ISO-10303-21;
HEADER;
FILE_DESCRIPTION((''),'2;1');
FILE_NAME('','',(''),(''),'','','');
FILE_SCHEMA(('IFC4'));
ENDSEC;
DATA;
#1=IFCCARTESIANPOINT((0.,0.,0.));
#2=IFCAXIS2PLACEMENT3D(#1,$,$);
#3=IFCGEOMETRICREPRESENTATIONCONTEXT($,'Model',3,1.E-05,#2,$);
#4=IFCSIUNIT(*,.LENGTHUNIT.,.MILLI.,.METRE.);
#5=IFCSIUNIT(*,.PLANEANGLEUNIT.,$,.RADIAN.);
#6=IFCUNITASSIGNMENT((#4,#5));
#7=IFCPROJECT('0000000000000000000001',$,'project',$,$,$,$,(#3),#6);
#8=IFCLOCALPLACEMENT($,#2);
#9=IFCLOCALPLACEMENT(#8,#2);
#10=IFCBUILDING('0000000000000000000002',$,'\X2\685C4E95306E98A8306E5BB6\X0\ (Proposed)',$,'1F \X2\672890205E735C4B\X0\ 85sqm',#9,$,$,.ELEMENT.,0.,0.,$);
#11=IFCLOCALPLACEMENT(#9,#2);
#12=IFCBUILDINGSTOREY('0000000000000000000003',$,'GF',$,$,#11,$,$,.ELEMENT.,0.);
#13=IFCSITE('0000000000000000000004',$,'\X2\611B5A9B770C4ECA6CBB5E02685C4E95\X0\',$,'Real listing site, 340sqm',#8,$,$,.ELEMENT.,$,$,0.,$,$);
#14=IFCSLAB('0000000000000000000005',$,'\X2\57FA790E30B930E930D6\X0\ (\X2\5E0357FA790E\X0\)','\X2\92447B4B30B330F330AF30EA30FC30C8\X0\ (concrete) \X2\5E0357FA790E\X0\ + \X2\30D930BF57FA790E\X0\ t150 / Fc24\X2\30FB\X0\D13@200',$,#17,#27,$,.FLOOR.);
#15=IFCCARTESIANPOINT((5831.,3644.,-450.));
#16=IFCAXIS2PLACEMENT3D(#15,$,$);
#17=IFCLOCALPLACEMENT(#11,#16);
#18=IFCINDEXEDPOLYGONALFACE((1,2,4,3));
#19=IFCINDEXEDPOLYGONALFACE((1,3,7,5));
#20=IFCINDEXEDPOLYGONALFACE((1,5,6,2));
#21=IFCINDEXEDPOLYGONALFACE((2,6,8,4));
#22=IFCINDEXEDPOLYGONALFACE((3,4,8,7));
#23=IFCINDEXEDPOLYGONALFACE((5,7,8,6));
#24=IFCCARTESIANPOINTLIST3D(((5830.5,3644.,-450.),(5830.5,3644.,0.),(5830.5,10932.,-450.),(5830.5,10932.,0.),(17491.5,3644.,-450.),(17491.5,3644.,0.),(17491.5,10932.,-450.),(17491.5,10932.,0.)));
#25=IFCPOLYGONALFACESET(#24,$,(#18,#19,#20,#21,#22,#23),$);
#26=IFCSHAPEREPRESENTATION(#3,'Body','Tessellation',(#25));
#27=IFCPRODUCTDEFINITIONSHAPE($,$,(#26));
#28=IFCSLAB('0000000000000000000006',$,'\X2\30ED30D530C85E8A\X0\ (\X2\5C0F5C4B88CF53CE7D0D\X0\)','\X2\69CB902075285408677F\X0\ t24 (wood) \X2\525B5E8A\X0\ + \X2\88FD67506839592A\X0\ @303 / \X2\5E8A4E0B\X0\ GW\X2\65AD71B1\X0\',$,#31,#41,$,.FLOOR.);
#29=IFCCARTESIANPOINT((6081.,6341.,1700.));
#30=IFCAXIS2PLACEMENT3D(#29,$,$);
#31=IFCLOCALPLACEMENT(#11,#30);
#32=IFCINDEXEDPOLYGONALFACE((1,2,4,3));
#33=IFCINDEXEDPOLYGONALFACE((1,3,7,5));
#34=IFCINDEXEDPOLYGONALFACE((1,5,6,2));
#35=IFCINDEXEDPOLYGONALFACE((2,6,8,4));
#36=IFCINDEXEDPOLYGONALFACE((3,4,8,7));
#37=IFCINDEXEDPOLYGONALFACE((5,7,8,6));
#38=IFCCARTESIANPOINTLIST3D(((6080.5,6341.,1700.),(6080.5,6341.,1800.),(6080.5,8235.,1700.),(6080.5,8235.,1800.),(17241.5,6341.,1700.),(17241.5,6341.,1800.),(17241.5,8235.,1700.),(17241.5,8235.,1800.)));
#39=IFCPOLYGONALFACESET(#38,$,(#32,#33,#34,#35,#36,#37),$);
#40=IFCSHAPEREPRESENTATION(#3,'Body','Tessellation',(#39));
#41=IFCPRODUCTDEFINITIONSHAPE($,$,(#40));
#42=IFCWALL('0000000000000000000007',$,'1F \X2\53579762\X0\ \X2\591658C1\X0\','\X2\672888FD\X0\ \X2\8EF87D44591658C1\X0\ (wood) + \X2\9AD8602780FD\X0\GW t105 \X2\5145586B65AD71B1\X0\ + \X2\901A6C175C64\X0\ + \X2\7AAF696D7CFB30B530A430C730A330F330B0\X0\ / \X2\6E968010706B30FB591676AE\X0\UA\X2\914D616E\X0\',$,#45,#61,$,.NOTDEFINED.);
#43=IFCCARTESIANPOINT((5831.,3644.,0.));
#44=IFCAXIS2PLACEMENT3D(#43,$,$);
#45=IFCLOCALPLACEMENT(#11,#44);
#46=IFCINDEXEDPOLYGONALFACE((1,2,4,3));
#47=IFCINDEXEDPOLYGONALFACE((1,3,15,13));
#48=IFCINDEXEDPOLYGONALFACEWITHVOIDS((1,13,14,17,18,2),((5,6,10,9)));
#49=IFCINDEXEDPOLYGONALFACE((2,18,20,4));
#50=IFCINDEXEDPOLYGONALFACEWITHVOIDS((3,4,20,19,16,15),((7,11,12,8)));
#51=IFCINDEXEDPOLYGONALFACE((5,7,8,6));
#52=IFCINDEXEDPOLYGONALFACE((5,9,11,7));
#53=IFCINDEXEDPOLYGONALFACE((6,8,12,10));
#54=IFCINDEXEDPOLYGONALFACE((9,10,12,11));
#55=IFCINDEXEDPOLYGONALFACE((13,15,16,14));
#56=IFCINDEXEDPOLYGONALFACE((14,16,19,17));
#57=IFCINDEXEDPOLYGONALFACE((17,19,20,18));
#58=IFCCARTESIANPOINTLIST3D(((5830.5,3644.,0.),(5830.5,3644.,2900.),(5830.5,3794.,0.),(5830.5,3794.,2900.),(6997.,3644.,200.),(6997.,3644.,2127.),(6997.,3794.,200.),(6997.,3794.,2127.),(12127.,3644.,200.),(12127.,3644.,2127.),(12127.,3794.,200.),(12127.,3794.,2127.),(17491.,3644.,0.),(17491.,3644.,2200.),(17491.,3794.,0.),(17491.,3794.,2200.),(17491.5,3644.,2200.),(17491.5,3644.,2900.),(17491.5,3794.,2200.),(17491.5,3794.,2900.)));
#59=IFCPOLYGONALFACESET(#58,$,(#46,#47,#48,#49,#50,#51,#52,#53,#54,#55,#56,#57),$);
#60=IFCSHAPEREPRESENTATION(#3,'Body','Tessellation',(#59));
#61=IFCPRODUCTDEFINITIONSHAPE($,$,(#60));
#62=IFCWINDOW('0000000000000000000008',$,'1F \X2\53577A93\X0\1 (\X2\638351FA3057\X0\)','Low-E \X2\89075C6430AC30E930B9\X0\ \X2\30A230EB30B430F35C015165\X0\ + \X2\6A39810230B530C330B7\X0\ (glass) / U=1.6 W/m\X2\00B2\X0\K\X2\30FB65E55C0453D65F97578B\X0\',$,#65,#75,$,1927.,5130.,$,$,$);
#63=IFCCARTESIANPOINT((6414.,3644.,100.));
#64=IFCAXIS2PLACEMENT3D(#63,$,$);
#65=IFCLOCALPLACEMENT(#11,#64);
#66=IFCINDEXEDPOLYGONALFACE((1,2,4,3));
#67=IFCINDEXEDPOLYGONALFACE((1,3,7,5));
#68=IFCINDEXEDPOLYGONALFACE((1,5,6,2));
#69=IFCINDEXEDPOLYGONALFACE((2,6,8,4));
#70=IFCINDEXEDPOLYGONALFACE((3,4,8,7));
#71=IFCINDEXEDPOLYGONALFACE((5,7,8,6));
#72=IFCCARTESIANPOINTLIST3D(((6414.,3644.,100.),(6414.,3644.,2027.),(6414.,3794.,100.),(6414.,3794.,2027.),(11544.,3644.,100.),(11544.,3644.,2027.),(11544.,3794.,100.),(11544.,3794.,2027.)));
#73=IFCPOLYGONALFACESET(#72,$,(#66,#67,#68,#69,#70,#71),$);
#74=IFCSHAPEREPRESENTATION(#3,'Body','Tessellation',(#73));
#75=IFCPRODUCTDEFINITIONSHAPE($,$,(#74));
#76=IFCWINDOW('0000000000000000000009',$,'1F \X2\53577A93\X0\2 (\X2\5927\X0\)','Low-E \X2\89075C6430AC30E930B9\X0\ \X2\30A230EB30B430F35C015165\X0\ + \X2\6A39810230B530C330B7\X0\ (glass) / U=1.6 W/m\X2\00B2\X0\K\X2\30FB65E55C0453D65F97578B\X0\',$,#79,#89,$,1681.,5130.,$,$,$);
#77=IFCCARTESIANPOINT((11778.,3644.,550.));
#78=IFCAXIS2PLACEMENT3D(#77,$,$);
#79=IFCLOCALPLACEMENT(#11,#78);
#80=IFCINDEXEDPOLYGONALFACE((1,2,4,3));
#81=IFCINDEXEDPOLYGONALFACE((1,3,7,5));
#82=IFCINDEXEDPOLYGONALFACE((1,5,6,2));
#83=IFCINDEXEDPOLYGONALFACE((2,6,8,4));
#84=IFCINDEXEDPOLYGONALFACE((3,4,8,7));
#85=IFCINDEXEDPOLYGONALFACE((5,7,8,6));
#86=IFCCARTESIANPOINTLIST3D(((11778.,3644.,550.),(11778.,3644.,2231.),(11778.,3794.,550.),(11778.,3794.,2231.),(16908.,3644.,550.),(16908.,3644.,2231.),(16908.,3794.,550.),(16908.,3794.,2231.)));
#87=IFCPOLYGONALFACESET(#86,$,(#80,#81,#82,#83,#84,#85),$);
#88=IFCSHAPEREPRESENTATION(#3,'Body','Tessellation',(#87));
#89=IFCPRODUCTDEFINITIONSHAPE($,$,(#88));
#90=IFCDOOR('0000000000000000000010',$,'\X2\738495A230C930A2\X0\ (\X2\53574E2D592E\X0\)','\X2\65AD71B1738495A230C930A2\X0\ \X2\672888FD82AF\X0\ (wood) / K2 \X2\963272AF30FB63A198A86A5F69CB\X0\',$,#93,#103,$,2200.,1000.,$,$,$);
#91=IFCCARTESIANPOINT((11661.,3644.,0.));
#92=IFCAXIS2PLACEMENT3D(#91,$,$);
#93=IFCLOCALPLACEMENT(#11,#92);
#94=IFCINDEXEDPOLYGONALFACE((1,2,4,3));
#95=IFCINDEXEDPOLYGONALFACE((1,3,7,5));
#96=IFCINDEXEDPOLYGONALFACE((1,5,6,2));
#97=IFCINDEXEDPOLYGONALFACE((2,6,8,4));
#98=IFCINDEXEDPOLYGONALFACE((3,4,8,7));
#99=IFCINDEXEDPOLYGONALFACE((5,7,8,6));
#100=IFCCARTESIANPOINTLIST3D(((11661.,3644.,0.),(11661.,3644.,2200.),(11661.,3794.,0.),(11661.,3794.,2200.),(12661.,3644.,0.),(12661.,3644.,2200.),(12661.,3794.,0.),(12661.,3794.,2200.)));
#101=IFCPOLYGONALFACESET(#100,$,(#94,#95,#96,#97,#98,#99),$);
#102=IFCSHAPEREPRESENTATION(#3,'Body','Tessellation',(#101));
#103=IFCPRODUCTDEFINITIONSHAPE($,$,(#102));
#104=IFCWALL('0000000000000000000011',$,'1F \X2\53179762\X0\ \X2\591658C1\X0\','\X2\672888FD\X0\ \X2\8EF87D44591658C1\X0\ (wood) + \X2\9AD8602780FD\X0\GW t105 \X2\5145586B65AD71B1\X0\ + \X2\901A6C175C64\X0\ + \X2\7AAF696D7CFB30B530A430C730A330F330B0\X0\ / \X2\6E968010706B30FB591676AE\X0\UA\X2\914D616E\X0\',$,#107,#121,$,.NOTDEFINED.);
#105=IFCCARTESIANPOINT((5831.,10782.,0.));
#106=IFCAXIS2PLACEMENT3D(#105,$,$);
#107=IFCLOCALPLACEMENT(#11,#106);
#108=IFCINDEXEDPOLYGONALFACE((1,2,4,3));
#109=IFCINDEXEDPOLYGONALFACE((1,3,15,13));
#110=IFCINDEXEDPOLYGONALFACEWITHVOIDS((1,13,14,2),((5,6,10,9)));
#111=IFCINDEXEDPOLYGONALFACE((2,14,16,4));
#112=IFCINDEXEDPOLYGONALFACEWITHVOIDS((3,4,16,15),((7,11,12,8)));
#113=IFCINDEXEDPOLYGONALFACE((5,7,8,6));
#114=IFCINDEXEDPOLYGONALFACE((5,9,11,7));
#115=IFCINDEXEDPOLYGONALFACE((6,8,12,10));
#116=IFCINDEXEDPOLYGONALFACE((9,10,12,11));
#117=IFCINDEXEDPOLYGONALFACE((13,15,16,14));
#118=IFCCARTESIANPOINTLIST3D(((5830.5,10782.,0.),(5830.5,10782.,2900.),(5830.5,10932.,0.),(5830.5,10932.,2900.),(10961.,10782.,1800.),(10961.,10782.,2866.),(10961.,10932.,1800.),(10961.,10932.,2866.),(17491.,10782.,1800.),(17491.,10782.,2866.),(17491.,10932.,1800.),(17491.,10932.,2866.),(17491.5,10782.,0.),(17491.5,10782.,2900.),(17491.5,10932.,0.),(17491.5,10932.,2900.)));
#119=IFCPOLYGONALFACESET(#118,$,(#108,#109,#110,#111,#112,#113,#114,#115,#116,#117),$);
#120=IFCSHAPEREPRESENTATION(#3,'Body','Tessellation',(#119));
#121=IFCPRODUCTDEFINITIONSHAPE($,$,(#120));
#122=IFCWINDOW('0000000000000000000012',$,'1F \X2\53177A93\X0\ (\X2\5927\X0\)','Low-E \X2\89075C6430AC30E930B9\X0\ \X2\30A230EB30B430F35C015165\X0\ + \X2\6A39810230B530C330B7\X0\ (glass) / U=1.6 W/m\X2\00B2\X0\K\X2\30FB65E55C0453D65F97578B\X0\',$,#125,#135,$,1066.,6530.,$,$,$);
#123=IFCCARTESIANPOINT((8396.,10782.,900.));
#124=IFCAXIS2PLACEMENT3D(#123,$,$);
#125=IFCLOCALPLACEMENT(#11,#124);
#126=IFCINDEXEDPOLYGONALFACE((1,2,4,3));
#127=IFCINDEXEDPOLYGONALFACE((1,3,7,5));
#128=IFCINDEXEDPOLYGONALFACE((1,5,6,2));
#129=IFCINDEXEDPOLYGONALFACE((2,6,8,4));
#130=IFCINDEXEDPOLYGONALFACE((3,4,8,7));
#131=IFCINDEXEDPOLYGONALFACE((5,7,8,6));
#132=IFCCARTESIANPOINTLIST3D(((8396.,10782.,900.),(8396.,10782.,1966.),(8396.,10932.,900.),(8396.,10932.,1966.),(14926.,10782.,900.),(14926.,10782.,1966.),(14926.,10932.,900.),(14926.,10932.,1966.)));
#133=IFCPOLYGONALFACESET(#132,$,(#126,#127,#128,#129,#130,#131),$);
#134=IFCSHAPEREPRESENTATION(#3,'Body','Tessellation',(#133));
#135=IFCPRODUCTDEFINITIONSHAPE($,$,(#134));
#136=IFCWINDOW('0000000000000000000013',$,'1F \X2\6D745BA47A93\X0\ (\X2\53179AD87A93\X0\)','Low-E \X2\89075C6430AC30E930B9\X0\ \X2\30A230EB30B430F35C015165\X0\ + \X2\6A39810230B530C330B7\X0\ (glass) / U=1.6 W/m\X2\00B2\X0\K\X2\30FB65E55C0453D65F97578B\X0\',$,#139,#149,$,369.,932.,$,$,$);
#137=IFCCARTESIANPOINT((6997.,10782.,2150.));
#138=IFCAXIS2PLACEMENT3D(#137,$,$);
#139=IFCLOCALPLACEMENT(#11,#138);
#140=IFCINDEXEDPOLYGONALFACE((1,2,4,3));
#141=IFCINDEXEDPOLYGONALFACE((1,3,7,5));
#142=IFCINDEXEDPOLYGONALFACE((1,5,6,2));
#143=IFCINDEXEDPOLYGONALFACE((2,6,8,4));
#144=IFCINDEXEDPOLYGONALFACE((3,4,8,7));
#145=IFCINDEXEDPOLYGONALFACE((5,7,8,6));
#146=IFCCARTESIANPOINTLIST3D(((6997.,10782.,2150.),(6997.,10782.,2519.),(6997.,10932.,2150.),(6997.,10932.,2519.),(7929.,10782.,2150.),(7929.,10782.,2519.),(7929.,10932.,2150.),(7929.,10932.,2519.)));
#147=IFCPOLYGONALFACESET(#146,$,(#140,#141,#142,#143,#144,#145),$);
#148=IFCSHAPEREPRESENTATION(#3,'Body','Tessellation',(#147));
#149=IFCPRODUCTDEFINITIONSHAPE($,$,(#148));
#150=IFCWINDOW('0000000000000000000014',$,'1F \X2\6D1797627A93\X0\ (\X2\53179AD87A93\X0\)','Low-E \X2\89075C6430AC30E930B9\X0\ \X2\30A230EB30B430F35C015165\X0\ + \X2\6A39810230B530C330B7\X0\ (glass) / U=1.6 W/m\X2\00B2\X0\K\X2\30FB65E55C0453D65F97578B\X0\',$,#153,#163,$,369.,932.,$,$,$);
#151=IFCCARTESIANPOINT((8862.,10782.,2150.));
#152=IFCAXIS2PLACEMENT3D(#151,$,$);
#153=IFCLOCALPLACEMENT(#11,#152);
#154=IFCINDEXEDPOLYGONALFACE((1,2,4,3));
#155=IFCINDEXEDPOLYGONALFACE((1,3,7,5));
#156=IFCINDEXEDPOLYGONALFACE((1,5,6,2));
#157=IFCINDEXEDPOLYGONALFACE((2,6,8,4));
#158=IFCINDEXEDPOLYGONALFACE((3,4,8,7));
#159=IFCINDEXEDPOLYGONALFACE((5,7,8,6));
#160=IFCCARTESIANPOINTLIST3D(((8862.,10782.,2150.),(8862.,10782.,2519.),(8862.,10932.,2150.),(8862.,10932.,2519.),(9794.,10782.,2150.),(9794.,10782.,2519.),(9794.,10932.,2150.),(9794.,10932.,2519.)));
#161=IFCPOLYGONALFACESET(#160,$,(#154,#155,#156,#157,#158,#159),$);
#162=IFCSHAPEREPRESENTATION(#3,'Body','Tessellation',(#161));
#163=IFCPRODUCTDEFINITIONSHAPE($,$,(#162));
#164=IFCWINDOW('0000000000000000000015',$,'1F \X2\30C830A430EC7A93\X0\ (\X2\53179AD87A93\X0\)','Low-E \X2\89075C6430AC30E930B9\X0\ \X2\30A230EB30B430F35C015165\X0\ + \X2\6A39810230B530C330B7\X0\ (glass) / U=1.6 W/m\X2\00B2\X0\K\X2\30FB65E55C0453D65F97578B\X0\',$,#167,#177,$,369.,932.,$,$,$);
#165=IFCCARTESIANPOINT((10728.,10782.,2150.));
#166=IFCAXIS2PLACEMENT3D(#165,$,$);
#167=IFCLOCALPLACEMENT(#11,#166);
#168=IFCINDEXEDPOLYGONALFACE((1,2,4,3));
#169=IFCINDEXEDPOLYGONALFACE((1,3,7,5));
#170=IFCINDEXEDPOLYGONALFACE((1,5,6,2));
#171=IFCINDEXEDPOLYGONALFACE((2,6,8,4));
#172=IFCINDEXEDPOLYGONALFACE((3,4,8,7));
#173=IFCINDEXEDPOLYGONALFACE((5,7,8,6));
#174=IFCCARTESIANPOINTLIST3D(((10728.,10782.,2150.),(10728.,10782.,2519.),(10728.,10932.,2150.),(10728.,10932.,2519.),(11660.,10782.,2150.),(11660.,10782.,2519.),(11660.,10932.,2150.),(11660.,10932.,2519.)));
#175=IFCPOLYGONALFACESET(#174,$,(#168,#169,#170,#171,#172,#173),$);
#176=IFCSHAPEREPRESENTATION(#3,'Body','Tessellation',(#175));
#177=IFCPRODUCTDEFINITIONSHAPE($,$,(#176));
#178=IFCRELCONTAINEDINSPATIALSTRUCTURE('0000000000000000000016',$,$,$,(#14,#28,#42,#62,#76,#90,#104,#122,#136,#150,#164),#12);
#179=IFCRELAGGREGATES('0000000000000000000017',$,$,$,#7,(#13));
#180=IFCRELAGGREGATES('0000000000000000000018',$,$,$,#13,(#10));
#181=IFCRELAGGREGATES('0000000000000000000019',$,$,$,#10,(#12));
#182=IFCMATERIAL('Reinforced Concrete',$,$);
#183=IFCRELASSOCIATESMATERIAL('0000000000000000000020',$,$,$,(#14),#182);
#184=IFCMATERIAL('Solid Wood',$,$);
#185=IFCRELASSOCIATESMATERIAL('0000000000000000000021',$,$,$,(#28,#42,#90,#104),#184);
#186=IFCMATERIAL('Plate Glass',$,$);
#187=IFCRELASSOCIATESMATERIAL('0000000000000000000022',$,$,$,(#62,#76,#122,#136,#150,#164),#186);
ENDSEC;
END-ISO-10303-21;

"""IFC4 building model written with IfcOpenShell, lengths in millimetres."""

from ifc_helpers import new_model, si_unit, frame, frame_2d, origin, place, context, project, spatial, rectangle, extrude, material, element, fill, save


model = new_model("IFC4")

# Units and contexts
model_context = context("Model", 3, precision=1e-05, world=origin())
ifc_project = project(units=[si_unit("LENGTHUNIT", "METRE", prefix="MILLI"), si_unit("PLANEANGLEUNIT", "RADIAN")], contexts=[model_context])

# Site, building, storey
site_placement = place(None, origin())
site = spatial("IfcSite", under=ifc_project, at=site_placement, Name="愛媛県今治市桜井", ObjectType="Real listing site, 340sqm", CompositionType="ELEMENT", RefElevation=0.0)
building_placement = place(site_placement, origin())
building = spatial("IfcBuilding", under=site, at=building_placement, Name="桜井の風の家 (Proposed)", ObjectType="1F 木造平屋 85sqm", CompositionType="ELEMENT", ElevationOfRefHeight=0.0, ElevationOfTerrain=0.0)
storey_placement = place(building_placement, origin())
storey = spatial("IfcBuildingStorey", under=building, at=storey_placement, Name="GF", CompositionType="ELEMENT", Elevation=0.0)

# Slabs
ifc_material_1 = material(Name="Reinforced Concrete")
slab_1_placement = place(storey_placement, frame((5831.0, 3644.0, -450.0)))
element("IfcSlab", 1, at=slab_1_placement, inside=storey, material=ifc_material_1, Name="基礎スラブ (布基礎)", Description="鉄筋コンクリート (concrete) 布基礎 + ベタ基礎 t150 / Fc24・D13@200", PredefinedType="FLOOR", context=model_context, shape_type="SweptSolid", body=[
    extrude(rectangle(XDim=11661.0, YDim=7288.0, at=frame_2d((5830.0, 3644.0))), frame((5831.0, 3644.0, -450.0)), (0.0, 0.0, 1.0), 450.0),
])
ifc_material_2 = material(Name="Solid Wood")
slab_2_placement = place(storey_placement, frame((6081.0, 6341.0, 1700.0)))
element("IfcSlab", 2, at=slab_2_placement, inside=storey, material=ifc_material_2, Name="ロフト床 (小屋裏収納)", Description="構造用合板 t24 (wood) 剛床 + 製材根太 @303 / 床下 GW断熱", PredefinedType="FLOOR", context=model_context, shape_type="SweptSolid", body=[
    extrude(rectangle(XDim=11161.0, YDim=1894.0, at=frame_2d((5580.0, 947.0))), frame((6081.0, 6341.0, 1700.0)), (0.0, 0.0, 1.0), 100.0),
])

# Wall, openings, windows, door
wall_1_placement = place(storey_placement, frame((5831.0, 3644.0, 0.0)))
wall_1 = element("IfcWall", 3, at=wall_1_placement, inside=storey, material=ifc_material_2, Name="1F 南面 外壁", Description="木製 軸組外壁 (wood) + 高性能GW t105 充填断熱 + 通気層 + 窯業系サイディング / 準耐火・外皮UA配慮", PredefinedType="NOTDEFINED", context=model_context, shape_type="SweptSolid", body=[
    extrude(rectangle(XDim=11661.0, YDim=150.0, at=frame_2d((5830.0, 75.0))), frame((5831.0, 3644.0, 0.0)), (0.0, 0.0, 1.0), 2900.0),
])
opening_1_placement = place(storey_placement, frame((6414.0, 3644.0, 100.0)))
opening_1 = element("IfcOpeningElement", 4, at=opening_1_placement, cuts=wall_1, PredefinedType="NOTDEFINED", context=model_context, shape_type="SweptSolid", body=[
    extrude(rectangle(XDim=5130.0, YDim=150.0, at=frame_2d((2565.0, 75.0))), frame((6414.0, 3644.0, 100.0)), (0.0, 0.0, 1.0), 1927.0),
])
opening_2_placement = place(storey_placement, frame((11778.0, 3644.0, 550.0)))
opening_2 = element("IfcOpeningElement", 5, at=opening_2_placement, cuts=wall_1, PredefinedType="NOTDEFINED", context=model_context, shape_type="SweptSolid", body=[
    extrude(rectangle(XDim=5130.0, YDim=150.0, at=frame_2d((2565.0, 75.0))), frame((11778.0, 3644.0, 550.0)), (0.0, 0.0, 1.0), 1681.0),
])
opening_3_placement = place(storey_placement, frame((11661.0, 3644.0, 0.0)))
opening_3 = element("IfcOpeningElement", 6, at=opening_3_placement, cuts=wall_1, PredefinedType="NOTDEFINED", context=model_context, shape_type="SweptSolid", body=[
    extrude(rectangle(XDim=1000.0, YDim=150.0, at=frame_2d((500.0, 75.0))), frame((11661.0, 3644.0, 0.0)), (0.0, 0.0, 1.0), 2200.0),
])
ifc_material_3 = material(Name="Plate Glass")
window_1_placement = place(storey_placement, frame((6414.0, 3644.0, 100.0)))
window_1 = element("IfcWindow", 7, at=window_1_placement, inside=storey, material=ifc_material_3, Name="1F 南窓1 (掃出し)", Description="Low-E 複層ガラス アルゴン封入 + 樹脂サッシ (glass) / U=1.6 W/m²K・日射取得型", OverallHeight=1927.0, OverallWidth=5130.0, context=model_context, shape_type="SweptSolid", body=[
    extrude(rectangle(XDim=5130.0, YDim=150.0, at=frame_2d((2565.0, 75.0))), frame((6414.0, 3644.0, 100.0)), (0.0, 0.0, 1.0), 1927.0),
])
fill(opening_1, window_1)
window_2_placement = place(storey_placement, frame((11778.0, 3644.0, 550.0)))
window_2 = element("IfcWindow", 8, at=window_2_placement, inside=storey, material=ifc_material_3, Name="1F 南窓2 (大)", Description="Low-E 複層ガラス アルゴン封入 + 樹脂サッシ (glass) / U=1.6 W/m²K・日射取得型", OverallHeight=1681.0, OverallWidth=5130.0, context=model_context, shape_type="SweptSolid", body=[
    extrude(rectangle(XDim=5130.0, YDim=150.0, at=frame_2d((2565.0, 75.0))), frame((11778.0, 3644.0, 550.0)), (0.0, 0.0, 1.0), 1681.0),
])
fill(opening_2, window_2)
door_1_placement = place(storey_placement, frame((11661.0, 3644.0, 0.0)))
door_1 = element("IfcDoor", 9, at=door_1_placement, inside=storey, material=ifc_material_2, Name="玄関ドア (南中央)", Description="断熱玄関ドア 木製芯 (wood) / K2 防犯・採風機構", OverallHeight=2200.0, OverallWidth=1000.0, context=model_context, shape_type="SweptSolid", body=[
    extrude(rectangle(XDim=1000.0, YDim=150.0, at=frame_2d((500.0, 75.0))), frame((11661.0, 3644.0, 0.0)), (0.0, 0.0, 1.0), 2200.0),
])
fill(opening_3, door_1)

# Wall, openings, windows
wall_2_placement = place(storey_placement, frame((5831.0, 10782.0, 0.0)))
wall_2 = element("IfcWall", 10, at=wall_2_placement, inside=storey, material=ifc_material_2, Name="1F 北面 外壁", Description="木製 軸組外壁 (wood) + 高性能GW t105 充填断熱 + 通気層 + 窯業系サイディング / 準耐火・外皮UA配慮", PredefinedType="NOTDEFINED", context=model_context, shape_type="SweptSolid", body=[
    extrude(rectangle(XDim=11661.0, YDim=150.0, at=frame_2d((5830.0, 75.0))), frame((5831.0, 10782.0, 0.0)), (0.0, 0.0, 1.0), 2900.0),
])
opening_4_placement = place(storey_placement, frame((8396.0, 10782.0, 900.0)))
opening_4 = element("IfcOpeningElement", 11, at=opening_4_placement, cuts=wall_2, PredefinedType="NOTDEFINED", context=model_context, shape_type="SweptSolid", body=[
    extrude(rectangle(XDim=6530.0, YDim=150.0, at=frame_2d((3265.0, 75.0))), frame((8396.0, 10782.0, 900.0)), (0.0, 0.0, 1.0), 1066.0),
])
opening_5_placement = place(storey_placement, frame((6997.0, 10782.0, 2150.0)))
opening_5 = element("IfcOpeningElement", 12, at=opening_5_placement, cuts=wall_2, PredefinedType="NOTDEFINED", context=model_context, shape_type="SweptSolid", body=[
    extrude(rectangle(XDim=932.0, YDim=150.0, at=frame_2d((466.0, 75.0))), frame((6997.0, 10782.0, 2150.0)), (0.0, 0.0, 1.0), 369.0),
])
opening_6_placement = place(storey_placement, frame((8862.0, 10782.0, 2150.0)))
opening_6 = element("IfcOpeningElement", 13, at=opening_6_placement, cuts=wall_2, PredefinedType="NOTDEFINED", context=model_context, shape_type="SweptSolid", body=[
    extrude(rectangle(XDim=932.0, YDim=150.0, at=frame_2d((466.0, 75.0))), frame((8862.0, 10782.0, 2150.0)), (0.0, 0.0, 1.0), 369.0),
])
opening_7_placement = place(storey_placement, frame((10728.0, 10782.0, 2150.0)))
opening_7 = element("IfcOpeningElement", 14, at=opening_7_placement, cuts=wall_2, PredefinedType="NOTDEFINED", context=model_context, shape_type="SweptSolid", body=[
    extrude(rectangle(XDim=932.0, YDim=150.0, at=frame_2d((466.0, 75.0))), frame((10728.0, 10782.0, 2150.0)), (0.0, 0.0, 1.0), 369.0),
])
window_3_placement = place(storey_placement, frame((8396.0, 10782.0, 900.0)))
window_3 = element("IfcWindow", 15, at=window_3_placement, inside=storey, material=ifc_material_3, Name="1F 北窓 (大)", Description="Low-E 複層ガラス アルゴン封入 + 樹脂サッシ (glass) / U=1.6 W/m²K・日射取得型", OverallHeight=1066.0, OverallWidth=6530.0, context=model_context, shape_type="SweptSolid", body=[
    extrude(rectangle(XDim=6530.0, YDim=150.0, at=frame_2d((3265.0, 75.0))), frame((8396.0, 10782.0, 900.0)), (0.0, 0.0, 1.0), 1066.0),
])
fill(opening_4, window_3)
window_4_placement = place(storey_placement, frame((6997.0, 10782.0, 2150.0)))
window_4 = element("IfcWindow", 16, at=window_4_placement, inside=storey, material=ifc_material_3, Name="1F 浴室窓 (北高窓)", Description="Low-E 複層ガラス アルゴン封入 + 樹脂サッシ (glass) / U=1.6 W/m²K・日射取得型", OverallHeight=369.0, OverallWidth=932.0, context=model_context, shape_type="SweptSolid", body=[
    extrude(rectangle(XDim=932.0, YDim=150.0, at=frame_2d((466.0, 75.0))), frame((6997.0, 10782.0, 2150.0)), (0.0, 0.0, 1.0), 369.0),
])
fill(opening_5, window_4)
window_5_placement = place(storey_placement, frame((8862.0, 10782.0, 2150.0)))
window_5 = element("IfcWindow", 17, at=window_5_placement, inside=storey, material=ifc_material_3, Name="1F 洗面窓 (北高窓)", Description="Low-E 複層ガラス アルゴン封入 + 樹脂サッシ (glass) / U=1.6 W/m²K・日射取得型", OverallHeight=369.0, OverallWidth=932.0, context=model_context, shape_type="SweptSolid", body=[
    extrude(rectangle(XDim=932.0, YDim=150.0, at=frame_2d((466.0, 75.0))), frame((8862.0, 10782.0, 2150.0)), (0.0, 0.0, 1.0), 369.0),
])
fill(opening_6, window_5)
window_6_placement = place(storey_placement, frame((10728.0, 10782.0, 2150.0)))
window_6 = element("IfcWindow", 18, at=window_6_placement, inside=storey, material=ifc_material_3, Name="1F トイレ窓 (北高窓)", Description="Low-E 複層ガラス アルゴン封入 + 樹脂サッシ (glass) / U=1.6 W/m²K・日射取得型", OverallHeight=369.0, OverallWidth=932.0, context=model_context, shape_type="SweptSolid", body=[
    extrude(rectangle(XDim=932.0, YDim=150.0, at=frame_2d((466.0, 75.0))), frame((10728.0, 10782.0, 2150.0)), (0.0, 0.0, 1.0), 369.0),
])
fill(opening_7, window_6)

save(model, "model.ifc")
